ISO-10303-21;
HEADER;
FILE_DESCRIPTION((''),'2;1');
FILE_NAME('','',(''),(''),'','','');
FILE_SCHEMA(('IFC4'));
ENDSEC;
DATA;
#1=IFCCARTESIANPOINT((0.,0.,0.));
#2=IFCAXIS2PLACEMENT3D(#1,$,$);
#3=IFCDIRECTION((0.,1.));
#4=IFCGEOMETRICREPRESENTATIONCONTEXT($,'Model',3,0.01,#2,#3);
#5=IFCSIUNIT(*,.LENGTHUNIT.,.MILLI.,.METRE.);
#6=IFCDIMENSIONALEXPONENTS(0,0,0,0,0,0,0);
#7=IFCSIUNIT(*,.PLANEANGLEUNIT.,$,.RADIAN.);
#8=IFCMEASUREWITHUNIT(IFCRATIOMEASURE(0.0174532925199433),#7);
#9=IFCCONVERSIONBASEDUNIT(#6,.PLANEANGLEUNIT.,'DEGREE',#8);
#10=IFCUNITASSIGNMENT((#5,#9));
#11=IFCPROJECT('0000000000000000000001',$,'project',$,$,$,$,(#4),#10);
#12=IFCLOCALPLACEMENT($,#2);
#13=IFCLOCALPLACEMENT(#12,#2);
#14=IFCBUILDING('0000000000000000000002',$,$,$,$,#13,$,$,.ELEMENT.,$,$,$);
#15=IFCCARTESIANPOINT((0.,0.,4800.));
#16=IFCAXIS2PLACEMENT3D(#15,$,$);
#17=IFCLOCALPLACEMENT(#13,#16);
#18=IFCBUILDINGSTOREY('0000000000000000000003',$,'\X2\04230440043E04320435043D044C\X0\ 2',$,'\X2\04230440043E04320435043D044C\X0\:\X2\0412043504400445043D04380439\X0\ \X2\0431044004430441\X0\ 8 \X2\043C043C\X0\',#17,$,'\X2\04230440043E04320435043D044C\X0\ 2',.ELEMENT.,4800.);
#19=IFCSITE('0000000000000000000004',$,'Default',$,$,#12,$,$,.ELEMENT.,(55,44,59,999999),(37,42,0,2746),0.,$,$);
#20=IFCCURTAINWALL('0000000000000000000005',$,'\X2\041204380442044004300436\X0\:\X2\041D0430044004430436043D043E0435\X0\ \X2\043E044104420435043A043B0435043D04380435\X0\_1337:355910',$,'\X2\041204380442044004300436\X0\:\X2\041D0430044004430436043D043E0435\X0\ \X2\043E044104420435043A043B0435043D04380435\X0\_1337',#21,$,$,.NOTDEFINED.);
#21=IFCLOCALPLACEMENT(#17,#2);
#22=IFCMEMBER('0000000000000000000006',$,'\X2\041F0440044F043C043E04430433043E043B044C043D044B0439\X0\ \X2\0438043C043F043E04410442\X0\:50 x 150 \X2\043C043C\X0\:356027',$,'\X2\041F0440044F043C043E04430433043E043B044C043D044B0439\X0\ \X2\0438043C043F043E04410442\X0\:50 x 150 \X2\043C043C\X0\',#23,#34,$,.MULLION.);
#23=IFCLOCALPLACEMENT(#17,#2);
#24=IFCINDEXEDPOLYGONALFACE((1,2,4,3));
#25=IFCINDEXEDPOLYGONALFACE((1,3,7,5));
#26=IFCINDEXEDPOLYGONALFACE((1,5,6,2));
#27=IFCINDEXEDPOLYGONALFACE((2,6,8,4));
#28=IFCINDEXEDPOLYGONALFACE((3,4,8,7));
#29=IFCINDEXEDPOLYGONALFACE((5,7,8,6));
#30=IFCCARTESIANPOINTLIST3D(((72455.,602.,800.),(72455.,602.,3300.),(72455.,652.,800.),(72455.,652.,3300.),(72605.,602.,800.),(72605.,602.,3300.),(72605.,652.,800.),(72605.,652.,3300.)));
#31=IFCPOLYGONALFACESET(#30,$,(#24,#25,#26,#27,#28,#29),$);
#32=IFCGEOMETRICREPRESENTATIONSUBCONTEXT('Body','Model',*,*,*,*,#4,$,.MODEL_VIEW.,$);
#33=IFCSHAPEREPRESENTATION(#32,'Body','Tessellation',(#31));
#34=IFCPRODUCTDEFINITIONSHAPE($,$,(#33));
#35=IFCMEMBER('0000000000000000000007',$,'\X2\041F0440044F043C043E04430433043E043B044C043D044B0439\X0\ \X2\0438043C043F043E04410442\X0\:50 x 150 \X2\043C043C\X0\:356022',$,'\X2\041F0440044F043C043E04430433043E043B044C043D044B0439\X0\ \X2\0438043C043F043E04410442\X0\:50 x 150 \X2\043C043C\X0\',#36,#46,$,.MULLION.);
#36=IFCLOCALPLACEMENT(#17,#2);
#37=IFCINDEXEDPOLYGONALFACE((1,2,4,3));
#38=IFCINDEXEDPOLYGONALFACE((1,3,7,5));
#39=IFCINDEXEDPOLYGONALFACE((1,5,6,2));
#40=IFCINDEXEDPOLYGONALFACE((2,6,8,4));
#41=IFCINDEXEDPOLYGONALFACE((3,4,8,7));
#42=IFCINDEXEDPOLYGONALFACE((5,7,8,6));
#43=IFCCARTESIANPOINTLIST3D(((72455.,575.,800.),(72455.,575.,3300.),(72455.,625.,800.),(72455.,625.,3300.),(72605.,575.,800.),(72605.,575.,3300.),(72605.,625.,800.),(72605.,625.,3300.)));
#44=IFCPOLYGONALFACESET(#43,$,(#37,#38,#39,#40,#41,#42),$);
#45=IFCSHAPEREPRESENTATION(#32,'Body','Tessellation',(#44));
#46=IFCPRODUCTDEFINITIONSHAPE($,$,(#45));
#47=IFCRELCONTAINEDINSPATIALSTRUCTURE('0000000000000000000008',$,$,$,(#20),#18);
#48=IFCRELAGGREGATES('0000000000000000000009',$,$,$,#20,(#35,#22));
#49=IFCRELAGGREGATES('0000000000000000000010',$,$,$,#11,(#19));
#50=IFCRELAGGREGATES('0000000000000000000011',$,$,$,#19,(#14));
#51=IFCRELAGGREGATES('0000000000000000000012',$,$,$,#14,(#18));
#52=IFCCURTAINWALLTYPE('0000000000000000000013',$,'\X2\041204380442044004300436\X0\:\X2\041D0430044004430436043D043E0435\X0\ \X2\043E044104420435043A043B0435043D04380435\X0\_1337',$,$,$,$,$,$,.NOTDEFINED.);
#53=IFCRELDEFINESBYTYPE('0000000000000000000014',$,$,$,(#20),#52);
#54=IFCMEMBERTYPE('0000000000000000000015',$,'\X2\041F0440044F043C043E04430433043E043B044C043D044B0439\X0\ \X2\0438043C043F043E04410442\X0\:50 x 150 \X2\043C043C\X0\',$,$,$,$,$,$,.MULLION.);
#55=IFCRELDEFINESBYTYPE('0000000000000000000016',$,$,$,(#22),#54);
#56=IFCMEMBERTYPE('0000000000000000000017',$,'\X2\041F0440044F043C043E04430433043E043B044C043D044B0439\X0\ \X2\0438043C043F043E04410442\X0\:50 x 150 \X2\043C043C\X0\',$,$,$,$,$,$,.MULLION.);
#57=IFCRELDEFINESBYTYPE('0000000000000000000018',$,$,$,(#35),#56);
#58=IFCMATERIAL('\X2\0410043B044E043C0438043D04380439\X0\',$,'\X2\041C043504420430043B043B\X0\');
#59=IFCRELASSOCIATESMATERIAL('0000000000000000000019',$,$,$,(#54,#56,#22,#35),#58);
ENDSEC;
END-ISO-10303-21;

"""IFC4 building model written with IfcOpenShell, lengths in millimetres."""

from ifc_helpers import new_model, entity, si_unit, converted_unit, direction, frame, origin, origin_2d_with_axis, place, context, subcontext, project, spatial, rectangle, extrude, source, transform, mapped, material, material_profile, profile_set, profile_usage, type_object, type_shapes, element, aggregate, save


model = new_model("IFC4")

# Units and contexts
model_context = context("Model", 3, precision=0.01, world=origin(), true_north=direction((0.0, 1.0)))
body_context = subcontext(model_context, "Body", "Model", "MODEL_VIEW")
ifc_project = project(units=[si_unit("LENGTHUNIT", "METRE", prefix="MILLI"), converted_unit("PLANEANGLEUNIT", "DEGREE", entity("IfcRatioMeasure", 0.0174532925199433), si_unit("PLANEANGLEUNIT", "RADIAN"), dimensions=[0, 0, 0, 0, 0, 0, 0])], contexts=[model_context])

# Site, building, storey
site_placement = place(None, origin())
site = spatial("IfcSite", under=ifc_project, at=site_placement, Name="Default", CompositionType="ELEMENT", RefLatitude=(55, 44, 59, 999999), RefLongitude=(37, 42, 0, 2746), RefElevation=0.0)
building_placement = place(site_placement, origin())
building = spatial("IfcBuilding", under=site, at=building_placement, CompositionType="ELEMENT")
storey_placement = place(building_placement, frame((0.0, 0.0, 4800.0)))
storey = spatial("IfcBuildingStorey", under=building, at=storey_placement, Name="Уровень 2", ObjectType="Уровень:Верхний брус 8 мм", LongName="Уровень 2", CompositionType="ELEMENT", Elevation=4800.0)

# Shared definitions
ifc_material_1 = material(Name="Алюминий", Category="Металл")
ifc_material_profile = material_profile(ifc_material_1, rectangle(XDim=150.0, YDim=50.0, at=origin_2d_with_axis()), Name="50 x 150 мм")
ifc_profile_set = profile_set([ifc_material_profile], Name="50 x 150 мм")

# Curtain wall
curtain_wall_type_1 = type_object("IfcCurtainWallType", Name="Витраж:Наружное остекление_1337", PredefinedType="NOTDEFINED")
curtain_wall_1_placement = place(storey_placement, frame((0.0, 0.0, -4800.0)))
curtain_wall_1 = element("IfcCurtainWall", 1, at=curtain_wall_1_placement, inside=storey, type_object=curtain_wall_type_1, Name="Витраж:Наружное остекление_1337:355910", ObjectType="Витраж:Наружное остекление_1337", PredefinedType="NOTDEFINED")

# Members
member_type_1 = type_object("IfcMemberType", Name="Прямоугольный импост:50 x 150 мм", PredefinedType="MULLION", material=ifc_profile_set)
shared_shape_1 = source(origin(), body_context, "Body", "SweptSolid", [
    extrude(rectangle(XDim=150.0, YDim=50.0, at=origin_2d_with_axis()), frame((0.0, 0.0, -2500.0), z_axis=(0.0, 0.0, 1.0), x_axis=(0.0, -1.0, 0.0)), (0.0, 0.0, 1.0), 2500.0),
])
type_shapes(member_type_1, [shared_shape_1])
ifc_profile_usage_1 = profile_usage(ifc_profile_set)
member_1_placement = place(storey_placement, frame((72530.0, 627.0, 800.0), z_axis=(0.0, 0.0, -1.0), x_axis=(0.0, -1.0, 0.0)))
member_1 = element("IfcMember", 2, at=member_1_placement, type_object=member_type_1, material=ifc_profile_usage_1, Name="Прямоугольный импост:50 x 150 мм:356027", ObjectType="Прямоугольный импост:50 x 150 мм", PredefinedType="MULLION", context=body_context, shape_type="MappedRepresentation", body=[
    mapped(shared_shape_1, transform((0.0, 0.0, 0.0), scale=1.0)),
])
ifc_profile_usage_2 = profile_usage(ifc_profile_set)
member_type_2 = type_object("IfcMemberType", Name="Прямоугольный импост:50 x 150 мм", PredefinedType="MULLION", material=ifc_profile_set)
shared_shape_2 = source(origin(), body_context, "Body", "SweptSolid", [
    extrude(rectangle(XDim=150.0, YDim=50.0, at=origin_2d_with_axis()), frame((-25.0, 0.0, -2500.0), z_axis=(0.0, 0.0, 1.0), x_axis=(0.0, -1.0, 0.0)), (0.0, 0.0, 1.0), 2500.0),
])
type_shapes(member_type_2, [shared_shape_2])
member_2_placement = place(storey_placement, frame((72530.0, 575.0, 800.0), z_axis=(0.0, 0.0, -1.0), x_axis=(0.0, -1.0, 0.0)))
member_2 = element("IfcMember", 3, at=member_2_placement, type_object=member_type_2, material=ifc_profile_usage_2, Name="Прямоугольный импост:50 x 150 мм:356022", ObjectType="Прямоугольный импост:50 x 150 мм", PredefinedType="MULLION", context=body_context, shape_type="MappedRepresentation", body=[
    mapped(shared_shape_2, transform((0.0, 0.0, 0.0), scale=1.0)),
])

aggregate(curtain_wall_1, [member_2, member_1])

save(model, "model.ifc")
